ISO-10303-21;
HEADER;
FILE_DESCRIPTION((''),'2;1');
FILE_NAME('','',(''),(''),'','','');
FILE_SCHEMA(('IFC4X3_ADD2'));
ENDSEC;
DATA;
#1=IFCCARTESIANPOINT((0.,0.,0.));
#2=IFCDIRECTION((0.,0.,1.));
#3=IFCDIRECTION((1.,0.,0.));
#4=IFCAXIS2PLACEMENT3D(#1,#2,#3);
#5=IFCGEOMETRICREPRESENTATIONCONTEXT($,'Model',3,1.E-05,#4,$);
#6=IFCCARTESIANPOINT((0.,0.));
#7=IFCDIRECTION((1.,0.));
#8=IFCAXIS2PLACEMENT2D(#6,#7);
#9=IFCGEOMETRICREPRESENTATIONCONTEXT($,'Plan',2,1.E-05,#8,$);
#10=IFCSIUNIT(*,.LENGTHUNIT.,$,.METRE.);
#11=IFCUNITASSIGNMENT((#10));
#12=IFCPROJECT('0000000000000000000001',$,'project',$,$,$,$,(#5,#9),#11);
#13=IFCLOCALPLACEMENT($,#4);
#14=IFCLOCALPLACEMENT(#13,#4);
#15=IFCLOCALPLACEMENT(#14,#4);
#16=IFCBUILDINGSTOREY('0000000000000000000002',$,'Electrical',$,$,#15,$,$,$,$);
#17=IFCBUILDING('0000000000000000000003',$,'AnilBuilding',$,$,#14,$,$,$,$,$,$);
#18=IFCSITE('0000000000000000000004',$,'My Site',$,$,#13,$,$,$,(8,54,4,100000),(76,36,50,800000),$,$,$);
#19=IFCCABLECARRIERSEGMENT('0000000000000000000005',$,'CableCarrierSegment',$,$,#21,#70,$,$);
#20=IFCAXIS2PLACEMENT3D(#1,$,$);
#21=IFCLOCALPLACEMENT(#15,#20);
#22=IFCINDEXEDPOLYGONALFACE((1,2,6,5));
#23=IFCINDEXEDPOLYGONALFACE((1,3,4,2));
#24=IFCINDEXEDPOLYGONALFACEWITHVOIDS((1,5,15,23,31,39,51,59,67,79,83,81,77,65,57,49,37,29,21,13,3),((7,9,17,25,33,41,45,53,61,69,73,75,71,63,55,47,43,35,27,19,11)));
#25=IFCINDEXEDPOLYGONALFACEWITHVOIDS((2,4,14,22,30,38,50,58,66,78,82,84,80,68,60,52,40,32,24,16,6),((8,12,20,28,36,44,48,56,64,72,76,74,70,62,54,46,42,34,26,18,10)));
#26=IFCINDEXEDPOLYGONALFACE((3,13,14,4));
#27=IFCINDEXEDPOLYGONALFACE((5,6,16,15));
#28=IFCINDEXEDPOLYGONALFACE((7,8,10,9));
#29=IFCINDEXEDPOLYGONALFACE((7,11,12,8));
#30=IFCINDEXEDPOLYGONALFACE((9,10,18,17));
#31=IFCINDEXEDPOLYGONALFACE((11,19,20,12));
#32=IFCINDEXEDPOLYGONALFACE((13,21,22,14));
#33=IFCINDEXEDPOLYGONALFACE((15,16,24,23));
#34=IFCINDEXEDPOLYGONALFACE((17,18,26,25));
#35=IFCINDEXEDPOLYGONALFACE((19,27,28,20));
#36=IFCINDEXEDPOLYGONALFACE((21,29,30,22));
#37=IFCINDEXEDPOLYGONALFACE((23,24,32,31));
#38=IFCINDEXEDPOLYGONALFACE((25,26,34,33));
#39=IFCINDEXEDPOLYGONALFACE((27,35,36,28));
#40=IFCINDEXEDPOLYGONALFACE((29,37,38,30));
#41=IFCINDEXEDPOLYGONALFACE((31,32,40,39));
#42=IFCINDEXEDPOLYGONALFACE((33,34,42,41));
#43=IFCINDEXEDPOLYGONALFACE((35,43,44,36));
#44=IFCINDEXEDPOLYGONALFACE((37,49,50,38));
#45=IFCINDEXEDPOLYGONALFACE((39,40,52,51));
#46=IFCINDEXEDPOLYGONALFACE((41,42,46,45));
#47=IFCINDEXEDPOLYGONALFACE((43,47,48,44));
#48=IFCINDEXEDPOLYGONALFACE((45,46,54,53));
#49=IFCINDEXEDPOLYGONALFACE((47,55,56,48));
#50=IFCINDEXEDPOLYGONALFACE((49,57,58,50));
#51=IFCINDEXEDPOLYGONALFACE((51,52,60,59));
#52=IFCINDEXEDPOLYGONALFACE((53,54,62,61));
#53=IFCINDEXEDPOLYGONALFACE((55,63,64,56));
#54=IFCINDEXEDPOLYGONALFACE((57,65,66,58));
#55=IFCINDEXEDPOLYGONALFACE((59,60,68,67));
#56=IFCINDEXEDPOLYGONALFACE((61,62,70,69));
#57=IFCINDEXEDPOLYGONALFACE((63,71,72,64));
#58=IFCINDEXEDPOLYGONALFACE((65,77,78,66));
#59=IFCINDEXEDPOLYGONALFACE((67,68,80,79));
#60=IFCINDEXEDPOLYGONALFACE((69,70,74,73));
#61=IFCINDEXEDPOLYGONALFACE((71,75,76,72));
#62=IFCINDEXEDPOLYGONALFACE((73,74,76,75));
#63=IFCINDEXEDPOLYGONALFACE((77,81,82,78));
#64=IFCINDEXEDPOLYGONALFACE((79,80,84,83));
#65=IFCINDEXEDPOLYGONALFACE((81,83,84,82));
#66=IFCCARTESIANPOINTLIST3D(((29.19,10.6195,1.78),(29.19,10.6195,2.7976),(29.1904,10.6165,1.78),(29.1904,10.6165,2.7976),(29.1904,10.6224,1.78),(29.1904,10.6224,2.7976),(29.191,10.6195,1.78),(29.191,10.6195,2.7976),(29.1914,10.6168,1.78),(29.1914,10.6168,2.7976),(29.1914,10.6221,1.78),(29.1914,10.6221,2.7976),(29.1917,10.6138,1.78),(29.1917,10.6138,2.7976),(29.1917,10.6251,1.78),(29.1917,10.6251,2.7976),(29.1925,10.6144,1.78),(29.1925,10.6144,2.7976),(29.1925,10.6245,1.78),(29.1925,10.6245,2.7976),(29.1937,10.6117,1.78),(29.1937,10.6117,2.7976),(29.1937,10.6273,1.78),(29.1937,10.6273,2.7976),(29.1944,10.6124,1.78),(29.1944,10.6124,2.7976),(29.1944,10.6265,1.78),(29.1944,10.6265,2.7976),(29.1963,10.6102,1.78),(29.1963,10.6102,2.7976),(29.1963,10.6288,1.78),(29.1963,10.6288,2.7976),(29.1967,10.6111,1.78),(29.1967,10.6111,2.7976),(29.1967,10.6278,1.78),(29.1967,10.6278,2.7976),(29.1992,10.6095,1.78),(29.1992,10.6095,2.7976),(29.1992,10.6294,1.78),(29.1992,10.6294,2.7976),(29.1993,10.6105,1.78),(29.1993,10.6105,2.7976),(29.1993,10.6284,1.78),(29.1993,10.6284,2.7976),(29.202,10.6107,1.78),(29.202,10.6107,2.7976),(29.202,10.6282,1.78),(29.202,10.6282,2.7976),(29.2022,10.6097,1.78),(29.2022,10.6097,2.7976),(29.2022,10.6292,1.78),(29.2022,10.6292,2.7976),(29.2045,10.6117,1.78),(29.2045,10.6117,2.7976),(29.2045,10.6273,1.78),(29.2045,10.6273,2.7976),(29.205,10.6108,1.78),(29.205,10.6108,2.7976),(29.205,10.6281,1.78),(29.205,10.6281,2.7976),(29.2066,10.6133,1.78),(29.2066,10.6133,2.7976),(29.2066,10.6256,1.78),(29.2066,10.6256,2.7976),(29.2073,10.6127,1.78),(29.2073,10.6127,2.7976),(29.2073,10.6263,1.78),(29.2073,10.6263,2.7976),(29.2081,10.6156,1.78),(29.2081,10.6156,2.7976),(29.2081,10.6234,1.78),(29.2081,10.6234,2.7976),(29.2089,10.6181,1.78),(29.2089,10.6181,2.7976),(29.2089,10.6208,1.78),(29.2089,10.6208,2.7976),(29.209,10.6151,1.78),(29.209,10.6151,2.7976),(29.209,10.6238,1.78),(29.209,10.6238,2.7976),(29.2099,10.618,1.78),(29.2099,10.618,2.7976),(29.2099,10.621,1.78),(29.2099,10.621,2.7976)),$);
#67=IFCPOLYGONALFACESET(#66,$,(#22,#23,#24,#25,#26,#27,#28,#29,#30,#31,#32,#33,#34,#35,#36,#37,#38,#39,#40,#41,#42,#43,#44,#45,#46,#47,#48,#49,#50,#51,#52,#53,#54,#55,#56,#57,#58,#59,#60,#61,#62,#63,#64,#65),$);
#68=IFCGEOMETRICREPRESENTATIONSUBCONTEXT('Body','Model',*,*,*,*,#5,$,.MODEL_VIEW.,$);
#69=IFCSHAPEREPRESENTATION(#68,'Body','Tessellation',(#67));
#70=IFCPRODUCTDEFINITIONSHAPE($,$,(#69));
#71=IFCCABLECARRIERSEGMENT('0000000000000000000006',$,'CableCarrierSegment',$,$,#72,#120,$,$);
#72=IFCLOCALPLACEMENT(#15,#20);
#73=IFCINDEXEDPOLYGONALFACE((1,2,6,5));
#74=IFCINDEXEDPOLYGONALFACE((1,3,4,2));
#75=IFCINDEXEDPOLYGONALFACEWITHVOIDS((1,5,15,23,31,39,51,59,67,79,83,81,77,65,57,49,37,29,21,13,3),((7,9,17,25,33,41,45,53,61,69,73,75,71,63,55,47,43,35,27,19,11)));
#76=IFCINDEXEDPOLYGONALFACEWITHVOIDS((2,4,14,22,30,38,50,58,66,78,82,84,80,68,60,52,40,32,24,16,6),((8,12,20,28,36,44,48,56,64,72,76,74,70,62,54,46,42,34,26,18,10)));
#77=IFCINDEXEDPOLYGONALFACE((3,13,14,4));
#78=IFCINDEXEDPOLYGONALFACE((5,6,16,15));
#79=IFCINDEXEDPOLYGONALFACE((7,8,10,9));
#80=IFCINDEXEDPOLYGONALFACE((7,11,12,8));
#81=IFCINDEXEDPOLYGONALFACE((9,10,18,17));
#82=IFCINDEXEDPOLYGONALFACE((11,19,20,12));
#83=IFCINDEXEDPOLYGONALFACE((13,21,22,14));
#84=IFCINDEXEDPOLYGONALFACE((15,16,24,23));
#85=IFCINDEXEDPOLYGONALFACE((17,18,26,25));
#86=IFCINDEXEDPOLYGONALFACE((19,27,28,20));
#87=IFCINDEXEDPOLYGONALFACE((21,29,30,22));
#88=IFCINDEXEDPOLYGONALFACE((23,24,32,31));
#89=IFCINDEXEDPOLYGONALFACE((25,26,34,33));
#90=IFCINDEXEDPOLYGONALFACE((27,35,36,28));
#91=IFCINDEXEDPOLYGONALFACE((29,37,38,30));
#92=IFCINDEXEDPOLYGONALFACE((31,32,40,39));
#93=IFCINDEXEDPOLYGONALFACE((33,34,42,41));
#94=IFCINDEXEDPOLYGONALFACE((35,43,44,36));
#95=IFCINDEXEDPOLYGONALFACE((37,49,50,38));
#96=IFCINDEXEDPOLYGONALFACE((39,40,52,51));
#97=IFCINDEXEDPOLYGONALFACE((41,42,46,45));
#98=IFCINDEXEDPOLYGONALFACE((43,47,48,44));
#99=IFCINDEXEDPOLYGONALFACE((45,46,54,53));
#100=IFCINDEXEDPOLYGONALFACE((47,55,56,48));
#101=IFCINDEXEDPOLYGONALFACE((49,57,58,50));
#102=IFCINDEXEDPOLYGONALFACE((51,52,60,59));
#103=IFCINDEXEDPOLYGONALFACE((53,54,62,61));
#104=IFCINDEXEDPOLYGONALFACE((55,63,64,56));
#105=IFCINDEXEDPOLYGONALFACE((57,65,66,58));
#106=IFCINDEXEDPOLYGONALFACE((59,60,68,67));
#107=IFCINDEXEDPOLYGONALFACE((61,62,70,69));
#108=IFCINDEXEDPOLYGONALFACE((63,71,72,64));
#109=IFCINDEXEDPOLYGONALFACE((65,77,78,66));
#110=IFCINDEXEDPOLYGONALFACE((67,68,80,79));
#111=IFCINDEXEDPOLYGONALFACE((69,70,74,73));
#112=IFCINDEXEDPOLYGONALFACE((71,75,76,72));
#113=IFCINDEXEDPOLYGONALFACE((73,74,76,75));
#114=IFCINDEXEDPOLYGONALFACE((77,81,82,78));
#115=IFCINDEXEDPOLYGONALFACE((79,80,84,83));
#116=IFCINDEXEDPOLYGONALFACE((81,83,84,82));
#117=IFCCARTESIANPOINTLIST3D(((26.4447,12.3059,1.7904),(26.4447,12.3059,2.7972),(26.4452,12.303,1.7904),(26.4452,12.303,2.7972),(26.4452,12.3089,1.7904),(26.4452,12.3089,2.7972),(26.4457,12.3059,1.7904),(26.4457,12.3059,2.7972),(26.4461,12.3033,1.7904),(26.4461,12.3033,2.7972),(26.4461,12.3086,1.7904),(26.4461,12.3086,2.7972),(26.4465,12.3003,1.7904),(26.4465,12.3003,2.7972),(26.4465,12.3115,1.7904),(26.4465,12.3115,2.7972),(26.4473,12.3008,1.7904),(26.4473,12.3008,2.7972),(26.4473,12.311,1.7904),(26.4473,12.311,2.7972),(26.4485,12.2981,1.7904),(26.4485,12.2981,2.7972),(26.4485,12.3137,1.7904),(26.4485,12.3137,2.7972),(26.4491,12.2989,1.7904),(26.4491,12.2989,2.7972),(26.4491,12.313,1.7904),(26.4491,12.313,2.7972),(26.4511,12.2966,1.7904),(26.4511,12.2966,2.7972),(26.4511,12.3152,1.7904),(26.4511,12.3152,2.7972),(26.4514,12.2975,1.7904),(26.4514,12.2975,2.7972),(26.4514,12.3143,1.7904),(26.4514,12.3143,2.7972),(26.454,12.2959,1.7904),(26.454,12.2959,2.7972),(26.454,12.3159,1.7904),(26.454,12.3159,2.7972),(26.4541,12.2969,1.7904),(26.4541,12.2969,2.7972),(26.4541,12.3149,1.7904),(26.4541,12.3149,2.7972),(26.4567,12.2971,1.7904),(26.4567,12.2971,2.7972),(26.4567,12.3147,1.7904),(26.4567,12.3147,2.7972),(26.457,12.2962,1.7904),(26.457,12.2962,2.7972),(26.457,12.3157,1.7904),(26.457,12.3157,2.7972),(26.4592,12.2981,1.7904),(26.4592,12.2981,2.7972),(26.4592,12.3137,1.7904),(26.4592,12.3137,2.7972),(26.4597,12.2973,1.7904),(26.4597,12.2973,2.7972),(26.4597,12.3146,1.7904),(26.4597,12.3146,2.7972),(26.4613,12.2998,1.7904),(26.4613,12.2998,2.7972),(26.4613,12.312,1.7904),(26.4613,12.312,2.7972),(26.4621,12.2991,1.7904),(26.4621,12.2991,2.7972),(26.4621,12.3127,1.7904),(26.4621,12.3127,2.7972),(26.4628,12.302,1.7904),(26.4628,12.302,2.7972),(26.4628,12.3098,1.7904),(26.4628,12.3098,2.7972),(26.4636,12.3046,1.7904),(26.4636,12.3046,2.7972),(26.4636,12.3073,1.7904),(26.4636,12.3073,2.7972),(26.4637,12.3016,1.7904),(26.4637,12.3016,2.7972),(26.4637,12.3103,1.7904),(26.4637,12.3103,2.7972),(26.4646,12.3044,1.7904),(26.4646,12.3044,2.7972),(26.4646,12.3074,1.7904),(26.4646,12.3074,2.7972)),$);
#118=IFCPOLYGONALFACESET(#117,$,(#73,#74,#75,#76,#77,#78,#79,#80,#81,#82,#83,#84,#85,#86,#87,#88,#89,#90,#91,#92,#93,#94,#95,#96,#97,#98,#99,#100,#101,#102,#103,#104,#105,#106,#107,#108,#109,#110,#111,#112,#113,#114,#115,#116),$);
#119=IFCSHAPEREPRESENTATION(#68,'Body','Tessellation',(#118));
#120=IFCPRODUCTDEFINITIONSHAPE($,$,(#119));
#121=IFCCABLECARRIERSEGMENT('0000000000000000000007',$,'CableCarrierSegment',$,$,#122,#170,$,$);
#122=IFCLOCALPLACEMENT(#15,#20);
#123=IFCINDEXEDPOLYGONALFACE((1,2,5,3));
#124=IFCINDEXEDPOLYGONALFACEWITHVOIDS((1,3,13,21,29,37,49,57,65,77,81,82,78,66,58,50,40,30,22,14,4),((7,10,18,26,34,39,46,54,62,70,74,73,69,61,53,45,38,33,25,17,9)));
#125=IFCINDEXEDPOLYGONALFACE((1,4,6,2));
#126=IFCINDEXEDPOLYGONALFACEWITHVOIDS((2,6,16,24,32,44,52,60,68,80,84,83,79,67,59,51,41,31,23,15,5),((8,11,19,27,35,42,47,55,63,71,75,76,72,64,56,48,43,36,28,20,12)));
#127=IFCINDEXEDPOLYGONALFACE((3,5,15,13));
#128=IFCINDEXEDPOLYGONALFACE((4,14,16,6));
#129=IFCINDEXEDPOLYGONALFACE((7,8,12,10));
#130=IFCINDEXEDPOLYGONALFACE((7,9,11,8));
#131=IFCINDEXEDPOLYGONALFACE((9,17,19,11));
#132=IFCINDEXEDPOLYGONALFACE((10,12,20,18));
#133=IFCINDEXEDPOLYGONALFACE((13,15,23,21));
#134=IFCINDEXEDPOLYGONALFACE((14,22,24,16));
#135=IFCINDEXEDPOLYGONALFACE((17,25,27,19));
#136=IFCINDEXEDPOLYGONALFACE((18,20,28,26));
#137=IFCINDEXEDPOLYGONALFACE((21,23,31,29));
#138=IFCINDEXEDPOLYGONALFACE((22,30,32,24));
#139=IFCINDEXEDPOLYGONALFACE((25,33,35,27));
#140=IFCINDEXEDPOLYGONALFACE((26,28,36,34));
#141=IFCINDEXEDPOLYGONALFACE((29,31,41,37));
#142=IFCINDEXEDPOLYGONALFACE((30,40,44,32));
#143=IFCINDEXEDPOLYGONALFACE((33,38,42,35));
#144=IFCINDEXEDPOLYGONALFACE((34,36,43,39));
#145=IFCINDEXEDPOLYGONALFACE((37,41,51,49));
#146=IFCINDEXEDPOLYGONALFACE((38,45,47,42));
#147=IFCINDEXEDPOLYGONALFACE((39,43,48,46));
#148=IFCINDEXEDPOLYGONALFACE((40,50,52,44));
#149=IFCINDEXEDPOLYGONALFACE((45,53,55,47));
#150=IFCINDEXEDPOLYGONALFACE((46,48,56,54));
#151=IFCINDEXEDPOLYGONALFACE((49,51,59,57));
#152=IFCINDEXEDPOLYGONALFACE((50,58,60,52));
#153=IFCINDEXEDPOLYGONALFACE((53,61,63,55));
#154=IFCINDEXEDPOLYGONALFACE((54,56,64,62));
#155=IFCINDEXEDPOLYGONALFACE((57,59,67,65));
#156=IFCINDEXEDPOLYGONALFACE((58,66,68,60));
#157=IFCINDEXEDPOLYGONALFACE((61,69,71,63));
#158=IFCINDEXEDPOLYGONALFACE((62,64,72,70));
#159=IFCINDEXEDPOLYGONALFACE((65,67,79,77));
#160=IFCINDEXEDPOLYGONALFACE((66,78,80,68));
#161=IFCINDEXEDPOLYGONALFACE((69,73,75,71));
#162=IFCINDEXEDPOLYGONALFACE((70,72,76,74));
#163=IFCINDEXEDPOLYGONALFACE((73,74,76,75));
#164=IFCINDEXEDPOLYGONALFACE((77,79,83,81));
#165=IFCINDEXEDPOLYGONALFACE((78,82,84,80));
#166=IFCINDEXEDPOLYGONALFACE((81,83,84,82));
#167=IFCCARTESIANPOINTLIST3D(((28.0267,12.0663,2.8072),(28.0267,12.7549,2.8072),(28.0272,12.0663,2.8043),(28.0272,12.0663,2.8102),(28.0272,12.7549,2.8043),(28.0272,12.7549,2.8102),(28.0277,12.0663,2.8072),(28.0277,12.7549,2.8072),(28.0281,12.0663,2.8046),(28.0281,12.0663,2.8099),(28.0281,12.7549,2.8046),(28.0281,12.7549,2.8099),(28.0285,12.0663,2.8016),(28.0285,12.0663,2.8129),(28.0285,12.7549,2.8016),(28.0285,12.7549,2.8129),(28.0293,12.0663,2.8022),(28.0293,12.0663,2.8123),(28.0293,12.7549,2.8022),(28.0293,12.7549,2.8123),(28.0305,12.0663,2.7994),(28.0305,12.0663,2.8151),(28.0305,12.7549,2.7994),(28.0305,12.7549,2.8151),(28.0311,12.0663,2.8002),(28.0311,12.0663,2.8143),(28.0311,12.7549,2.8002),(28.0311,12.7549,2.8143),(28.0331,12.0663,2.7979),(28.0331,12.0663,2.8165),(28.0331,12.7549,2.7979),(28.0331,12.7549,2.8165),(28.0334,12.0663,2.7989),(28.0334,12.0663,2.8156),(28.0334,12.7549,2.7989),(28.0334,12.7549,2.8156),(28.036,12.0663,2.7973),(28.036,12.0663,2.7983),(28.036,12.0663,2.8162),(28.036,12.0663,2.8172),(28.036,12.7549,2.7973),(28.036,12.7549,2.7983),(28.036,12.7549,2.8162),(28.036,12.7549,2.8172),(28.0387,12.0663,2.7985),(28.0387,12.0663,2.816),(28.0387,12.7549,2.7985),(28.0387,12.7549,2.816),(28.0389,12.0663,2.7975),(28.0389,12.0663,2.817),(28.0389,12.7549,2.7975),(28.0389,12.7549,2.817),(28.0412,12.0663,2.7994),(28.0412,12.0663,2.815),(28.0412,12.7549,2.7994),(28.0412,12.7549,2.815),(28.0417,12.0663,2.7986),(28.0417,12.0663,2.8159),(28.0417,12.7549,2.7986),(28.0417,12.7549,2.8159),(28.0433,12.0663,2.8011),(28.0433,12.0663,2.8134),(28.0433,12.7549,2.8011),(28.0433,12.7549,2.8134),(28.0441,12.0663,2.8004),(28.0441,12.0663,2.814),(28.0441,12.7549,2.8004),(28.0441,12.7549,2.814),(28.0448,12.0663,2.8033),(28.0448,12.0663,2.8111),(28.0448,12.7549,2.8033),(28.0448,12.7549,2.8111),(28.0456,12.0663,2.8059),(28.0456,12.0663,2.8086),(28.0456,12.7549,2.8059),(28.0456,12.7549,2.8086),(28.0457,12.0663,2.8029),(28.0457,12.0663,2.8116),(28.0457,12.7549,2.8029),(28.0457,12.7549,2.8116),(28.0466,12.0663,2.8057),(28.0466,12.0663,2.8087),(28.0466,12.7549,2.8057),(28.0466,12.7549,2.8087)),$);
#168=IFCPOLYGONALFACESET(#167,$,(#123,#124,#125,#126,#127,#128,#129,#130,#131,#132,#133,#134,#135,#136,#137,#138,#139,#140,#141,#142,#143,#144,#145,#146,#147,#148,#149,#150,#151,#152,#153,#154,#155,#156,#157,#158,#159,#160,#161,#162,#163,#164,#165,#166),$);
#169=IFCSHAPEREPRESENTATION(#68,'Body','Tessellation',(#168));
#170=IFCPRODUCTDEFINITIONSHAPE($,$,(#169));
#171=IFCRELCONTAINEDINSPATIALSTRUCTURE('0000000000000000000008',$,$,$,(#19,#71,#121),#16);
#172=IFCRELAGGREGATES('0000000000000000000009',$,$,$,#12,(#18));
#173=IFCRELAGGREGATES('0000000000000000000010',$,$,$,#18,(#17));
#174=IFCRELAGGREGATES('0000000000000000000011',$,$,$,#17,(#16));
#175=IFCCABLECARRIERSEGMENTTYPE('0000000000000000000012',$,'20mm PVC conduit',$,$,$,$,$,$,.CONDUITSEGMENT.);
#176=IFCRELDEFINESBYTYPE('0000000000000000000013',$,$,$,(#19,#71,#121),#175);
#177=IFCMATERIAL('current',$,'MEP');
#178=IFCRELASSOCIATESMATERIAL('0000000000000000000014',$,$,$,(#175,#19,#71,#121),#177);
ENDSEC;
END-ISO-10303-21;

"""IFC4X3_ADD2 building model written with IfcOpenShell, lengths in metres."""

from ifc_helpers import new_model, si_unit, frame, origin_with_axes, origin_2d_with_axis, place, context, subcontext, project, spatial, hollow_circle, extrude, material, material_profile, profile_set, profile_usage, type_object, element, save


model = new_model("IFC4X3_ADD2")

# Units and contexts
model_context = context("Model", 3, precision=1e-05, world=origin_with_axes())
plan_context = context("Plan", 2, precision=1e-05, world=origin_2d_with_axis())
body_context = subcontext(model_context, "Body", "Model", "MODEL_VIEW")
ifc_project = project(units=[si_unit("LENGTHUNIT", "METRE")], contexts=[model_context, plan_context])

# Site, building, storey
site_placement = place(None, origin_with_axes())
site = spatial("IfcSite", under=ifc_project, at=site_placement, Name="My Site", RefLatitude=(8, 54, 4, 100000), RefLongitude=(76, 36, 50, 800000))
building_placement = place(site_placement, origin_with_axes())
building = spatial("IfcBuilding", under=site, at=building_placement, Name="AnilBuilding")
storey_placement = place(building_placement, origin_with_axes())
storey = spatial("IfcBuildingStorey", under=building, at=storey_placement, Name="Electrical")

# Cable carrier segments
ifc_material = material(Name="current", Category="MEP")
ifc_material_profile_1 = material_profile(ifc_material, hollow_circle(Radius=0.01, WallThickness=0.001))
ifc_profile_set_1 = profile_set([ifc_material_profile_1], Name="current")
ifc_material_profile_2 = material_profile(ifc_material, hollow_circle(Radius=0.01, WallThickness=0.001))
ifc_profile_set_2 = profile_set([ifc_material_profile_2], Name="current")
cable_carrier_segment_type = type_object("IfcCableCarrierSegmentType", Name="20mm PVC conduit", PredefinedType="CONDUITSEGMENT", material=ifc_profile_set_2)
ifc_profile_usage_1 = profile_usage(ifc_profile_set_1, cardinal=5)
cable_carrier_segment_1_placement = place(storey_placement, frame((29.2, 10.6195, 1.78), z_axis=(0.0, 0.0, 1.0), x_axis=(-1.0, 0.0, 0.0)))
element("IfcCableCarrierSegment", 1, at=cable_carrier_segment_1_placement, inside=storey, type_object=cable_carrier_segment_type, material=ifc_profile_usage_1, Name="CableCarrierSegment", context=body_context, shape_type="SweptSolid", body=[
    extrude(hollow_circle(Radius=0.01, WallThickness=0.001), origin_with_axes(), (0.0, 0.0, 1.0), 1.0176),
])
ifc_profile_usage_2 = profile_usage(ifc_profile_set_1, cardinal=5)
cable_carrier_segment_2_placement = place(storey_placement, frame((26.4547, 12.3059, 1.7904), z_axis=(0.0, 0.0, 1.0), x_axis=(-1.0, 0.0, 0.0)))
element("IfcCableCarrierSegment", 2, at=cable_carrier_segment_2_placement, inside=storey, type_object=cable_carrier_segment_type, material=ifc_profile_usage_2, Name="CableCarrierSegment", context=body_context, shape_type="SweptSolid", body=[
    extrude(hollow_circle(Radius=0.01, WallThickness=0.001), origin_with_axes(), (0.0, 0.0, 1.0), 1.0068),
])
ifc_profile_usage_3 = profile_usage(ifc_profile_set_1, cardinal=5)
cable_carrier_segment_3_placement = place(storey_placement, frame((28.0367, 12.0663, 2.8072), z_axis=(0.0, 1.0, 0.0), x_axis=(-1.0, 0.0, 0.0)))
element("IfcCableCarrierSegment", 3, at=cable_carrier_segment_3_placement, inside=storey, type_object=cable_carrier_segment_type, material=ifc_profile_usage_3, Name="CableCarrierSegment", context=body_context, shape_type="SweptSolid", body=[
    extrude(hollow_circle(Radius=0.01, WallThickness=0.001), origin_with_axes(), (0.0, 0.0, 1.0), 0.6886),
])

save(model, "model.ifc")
